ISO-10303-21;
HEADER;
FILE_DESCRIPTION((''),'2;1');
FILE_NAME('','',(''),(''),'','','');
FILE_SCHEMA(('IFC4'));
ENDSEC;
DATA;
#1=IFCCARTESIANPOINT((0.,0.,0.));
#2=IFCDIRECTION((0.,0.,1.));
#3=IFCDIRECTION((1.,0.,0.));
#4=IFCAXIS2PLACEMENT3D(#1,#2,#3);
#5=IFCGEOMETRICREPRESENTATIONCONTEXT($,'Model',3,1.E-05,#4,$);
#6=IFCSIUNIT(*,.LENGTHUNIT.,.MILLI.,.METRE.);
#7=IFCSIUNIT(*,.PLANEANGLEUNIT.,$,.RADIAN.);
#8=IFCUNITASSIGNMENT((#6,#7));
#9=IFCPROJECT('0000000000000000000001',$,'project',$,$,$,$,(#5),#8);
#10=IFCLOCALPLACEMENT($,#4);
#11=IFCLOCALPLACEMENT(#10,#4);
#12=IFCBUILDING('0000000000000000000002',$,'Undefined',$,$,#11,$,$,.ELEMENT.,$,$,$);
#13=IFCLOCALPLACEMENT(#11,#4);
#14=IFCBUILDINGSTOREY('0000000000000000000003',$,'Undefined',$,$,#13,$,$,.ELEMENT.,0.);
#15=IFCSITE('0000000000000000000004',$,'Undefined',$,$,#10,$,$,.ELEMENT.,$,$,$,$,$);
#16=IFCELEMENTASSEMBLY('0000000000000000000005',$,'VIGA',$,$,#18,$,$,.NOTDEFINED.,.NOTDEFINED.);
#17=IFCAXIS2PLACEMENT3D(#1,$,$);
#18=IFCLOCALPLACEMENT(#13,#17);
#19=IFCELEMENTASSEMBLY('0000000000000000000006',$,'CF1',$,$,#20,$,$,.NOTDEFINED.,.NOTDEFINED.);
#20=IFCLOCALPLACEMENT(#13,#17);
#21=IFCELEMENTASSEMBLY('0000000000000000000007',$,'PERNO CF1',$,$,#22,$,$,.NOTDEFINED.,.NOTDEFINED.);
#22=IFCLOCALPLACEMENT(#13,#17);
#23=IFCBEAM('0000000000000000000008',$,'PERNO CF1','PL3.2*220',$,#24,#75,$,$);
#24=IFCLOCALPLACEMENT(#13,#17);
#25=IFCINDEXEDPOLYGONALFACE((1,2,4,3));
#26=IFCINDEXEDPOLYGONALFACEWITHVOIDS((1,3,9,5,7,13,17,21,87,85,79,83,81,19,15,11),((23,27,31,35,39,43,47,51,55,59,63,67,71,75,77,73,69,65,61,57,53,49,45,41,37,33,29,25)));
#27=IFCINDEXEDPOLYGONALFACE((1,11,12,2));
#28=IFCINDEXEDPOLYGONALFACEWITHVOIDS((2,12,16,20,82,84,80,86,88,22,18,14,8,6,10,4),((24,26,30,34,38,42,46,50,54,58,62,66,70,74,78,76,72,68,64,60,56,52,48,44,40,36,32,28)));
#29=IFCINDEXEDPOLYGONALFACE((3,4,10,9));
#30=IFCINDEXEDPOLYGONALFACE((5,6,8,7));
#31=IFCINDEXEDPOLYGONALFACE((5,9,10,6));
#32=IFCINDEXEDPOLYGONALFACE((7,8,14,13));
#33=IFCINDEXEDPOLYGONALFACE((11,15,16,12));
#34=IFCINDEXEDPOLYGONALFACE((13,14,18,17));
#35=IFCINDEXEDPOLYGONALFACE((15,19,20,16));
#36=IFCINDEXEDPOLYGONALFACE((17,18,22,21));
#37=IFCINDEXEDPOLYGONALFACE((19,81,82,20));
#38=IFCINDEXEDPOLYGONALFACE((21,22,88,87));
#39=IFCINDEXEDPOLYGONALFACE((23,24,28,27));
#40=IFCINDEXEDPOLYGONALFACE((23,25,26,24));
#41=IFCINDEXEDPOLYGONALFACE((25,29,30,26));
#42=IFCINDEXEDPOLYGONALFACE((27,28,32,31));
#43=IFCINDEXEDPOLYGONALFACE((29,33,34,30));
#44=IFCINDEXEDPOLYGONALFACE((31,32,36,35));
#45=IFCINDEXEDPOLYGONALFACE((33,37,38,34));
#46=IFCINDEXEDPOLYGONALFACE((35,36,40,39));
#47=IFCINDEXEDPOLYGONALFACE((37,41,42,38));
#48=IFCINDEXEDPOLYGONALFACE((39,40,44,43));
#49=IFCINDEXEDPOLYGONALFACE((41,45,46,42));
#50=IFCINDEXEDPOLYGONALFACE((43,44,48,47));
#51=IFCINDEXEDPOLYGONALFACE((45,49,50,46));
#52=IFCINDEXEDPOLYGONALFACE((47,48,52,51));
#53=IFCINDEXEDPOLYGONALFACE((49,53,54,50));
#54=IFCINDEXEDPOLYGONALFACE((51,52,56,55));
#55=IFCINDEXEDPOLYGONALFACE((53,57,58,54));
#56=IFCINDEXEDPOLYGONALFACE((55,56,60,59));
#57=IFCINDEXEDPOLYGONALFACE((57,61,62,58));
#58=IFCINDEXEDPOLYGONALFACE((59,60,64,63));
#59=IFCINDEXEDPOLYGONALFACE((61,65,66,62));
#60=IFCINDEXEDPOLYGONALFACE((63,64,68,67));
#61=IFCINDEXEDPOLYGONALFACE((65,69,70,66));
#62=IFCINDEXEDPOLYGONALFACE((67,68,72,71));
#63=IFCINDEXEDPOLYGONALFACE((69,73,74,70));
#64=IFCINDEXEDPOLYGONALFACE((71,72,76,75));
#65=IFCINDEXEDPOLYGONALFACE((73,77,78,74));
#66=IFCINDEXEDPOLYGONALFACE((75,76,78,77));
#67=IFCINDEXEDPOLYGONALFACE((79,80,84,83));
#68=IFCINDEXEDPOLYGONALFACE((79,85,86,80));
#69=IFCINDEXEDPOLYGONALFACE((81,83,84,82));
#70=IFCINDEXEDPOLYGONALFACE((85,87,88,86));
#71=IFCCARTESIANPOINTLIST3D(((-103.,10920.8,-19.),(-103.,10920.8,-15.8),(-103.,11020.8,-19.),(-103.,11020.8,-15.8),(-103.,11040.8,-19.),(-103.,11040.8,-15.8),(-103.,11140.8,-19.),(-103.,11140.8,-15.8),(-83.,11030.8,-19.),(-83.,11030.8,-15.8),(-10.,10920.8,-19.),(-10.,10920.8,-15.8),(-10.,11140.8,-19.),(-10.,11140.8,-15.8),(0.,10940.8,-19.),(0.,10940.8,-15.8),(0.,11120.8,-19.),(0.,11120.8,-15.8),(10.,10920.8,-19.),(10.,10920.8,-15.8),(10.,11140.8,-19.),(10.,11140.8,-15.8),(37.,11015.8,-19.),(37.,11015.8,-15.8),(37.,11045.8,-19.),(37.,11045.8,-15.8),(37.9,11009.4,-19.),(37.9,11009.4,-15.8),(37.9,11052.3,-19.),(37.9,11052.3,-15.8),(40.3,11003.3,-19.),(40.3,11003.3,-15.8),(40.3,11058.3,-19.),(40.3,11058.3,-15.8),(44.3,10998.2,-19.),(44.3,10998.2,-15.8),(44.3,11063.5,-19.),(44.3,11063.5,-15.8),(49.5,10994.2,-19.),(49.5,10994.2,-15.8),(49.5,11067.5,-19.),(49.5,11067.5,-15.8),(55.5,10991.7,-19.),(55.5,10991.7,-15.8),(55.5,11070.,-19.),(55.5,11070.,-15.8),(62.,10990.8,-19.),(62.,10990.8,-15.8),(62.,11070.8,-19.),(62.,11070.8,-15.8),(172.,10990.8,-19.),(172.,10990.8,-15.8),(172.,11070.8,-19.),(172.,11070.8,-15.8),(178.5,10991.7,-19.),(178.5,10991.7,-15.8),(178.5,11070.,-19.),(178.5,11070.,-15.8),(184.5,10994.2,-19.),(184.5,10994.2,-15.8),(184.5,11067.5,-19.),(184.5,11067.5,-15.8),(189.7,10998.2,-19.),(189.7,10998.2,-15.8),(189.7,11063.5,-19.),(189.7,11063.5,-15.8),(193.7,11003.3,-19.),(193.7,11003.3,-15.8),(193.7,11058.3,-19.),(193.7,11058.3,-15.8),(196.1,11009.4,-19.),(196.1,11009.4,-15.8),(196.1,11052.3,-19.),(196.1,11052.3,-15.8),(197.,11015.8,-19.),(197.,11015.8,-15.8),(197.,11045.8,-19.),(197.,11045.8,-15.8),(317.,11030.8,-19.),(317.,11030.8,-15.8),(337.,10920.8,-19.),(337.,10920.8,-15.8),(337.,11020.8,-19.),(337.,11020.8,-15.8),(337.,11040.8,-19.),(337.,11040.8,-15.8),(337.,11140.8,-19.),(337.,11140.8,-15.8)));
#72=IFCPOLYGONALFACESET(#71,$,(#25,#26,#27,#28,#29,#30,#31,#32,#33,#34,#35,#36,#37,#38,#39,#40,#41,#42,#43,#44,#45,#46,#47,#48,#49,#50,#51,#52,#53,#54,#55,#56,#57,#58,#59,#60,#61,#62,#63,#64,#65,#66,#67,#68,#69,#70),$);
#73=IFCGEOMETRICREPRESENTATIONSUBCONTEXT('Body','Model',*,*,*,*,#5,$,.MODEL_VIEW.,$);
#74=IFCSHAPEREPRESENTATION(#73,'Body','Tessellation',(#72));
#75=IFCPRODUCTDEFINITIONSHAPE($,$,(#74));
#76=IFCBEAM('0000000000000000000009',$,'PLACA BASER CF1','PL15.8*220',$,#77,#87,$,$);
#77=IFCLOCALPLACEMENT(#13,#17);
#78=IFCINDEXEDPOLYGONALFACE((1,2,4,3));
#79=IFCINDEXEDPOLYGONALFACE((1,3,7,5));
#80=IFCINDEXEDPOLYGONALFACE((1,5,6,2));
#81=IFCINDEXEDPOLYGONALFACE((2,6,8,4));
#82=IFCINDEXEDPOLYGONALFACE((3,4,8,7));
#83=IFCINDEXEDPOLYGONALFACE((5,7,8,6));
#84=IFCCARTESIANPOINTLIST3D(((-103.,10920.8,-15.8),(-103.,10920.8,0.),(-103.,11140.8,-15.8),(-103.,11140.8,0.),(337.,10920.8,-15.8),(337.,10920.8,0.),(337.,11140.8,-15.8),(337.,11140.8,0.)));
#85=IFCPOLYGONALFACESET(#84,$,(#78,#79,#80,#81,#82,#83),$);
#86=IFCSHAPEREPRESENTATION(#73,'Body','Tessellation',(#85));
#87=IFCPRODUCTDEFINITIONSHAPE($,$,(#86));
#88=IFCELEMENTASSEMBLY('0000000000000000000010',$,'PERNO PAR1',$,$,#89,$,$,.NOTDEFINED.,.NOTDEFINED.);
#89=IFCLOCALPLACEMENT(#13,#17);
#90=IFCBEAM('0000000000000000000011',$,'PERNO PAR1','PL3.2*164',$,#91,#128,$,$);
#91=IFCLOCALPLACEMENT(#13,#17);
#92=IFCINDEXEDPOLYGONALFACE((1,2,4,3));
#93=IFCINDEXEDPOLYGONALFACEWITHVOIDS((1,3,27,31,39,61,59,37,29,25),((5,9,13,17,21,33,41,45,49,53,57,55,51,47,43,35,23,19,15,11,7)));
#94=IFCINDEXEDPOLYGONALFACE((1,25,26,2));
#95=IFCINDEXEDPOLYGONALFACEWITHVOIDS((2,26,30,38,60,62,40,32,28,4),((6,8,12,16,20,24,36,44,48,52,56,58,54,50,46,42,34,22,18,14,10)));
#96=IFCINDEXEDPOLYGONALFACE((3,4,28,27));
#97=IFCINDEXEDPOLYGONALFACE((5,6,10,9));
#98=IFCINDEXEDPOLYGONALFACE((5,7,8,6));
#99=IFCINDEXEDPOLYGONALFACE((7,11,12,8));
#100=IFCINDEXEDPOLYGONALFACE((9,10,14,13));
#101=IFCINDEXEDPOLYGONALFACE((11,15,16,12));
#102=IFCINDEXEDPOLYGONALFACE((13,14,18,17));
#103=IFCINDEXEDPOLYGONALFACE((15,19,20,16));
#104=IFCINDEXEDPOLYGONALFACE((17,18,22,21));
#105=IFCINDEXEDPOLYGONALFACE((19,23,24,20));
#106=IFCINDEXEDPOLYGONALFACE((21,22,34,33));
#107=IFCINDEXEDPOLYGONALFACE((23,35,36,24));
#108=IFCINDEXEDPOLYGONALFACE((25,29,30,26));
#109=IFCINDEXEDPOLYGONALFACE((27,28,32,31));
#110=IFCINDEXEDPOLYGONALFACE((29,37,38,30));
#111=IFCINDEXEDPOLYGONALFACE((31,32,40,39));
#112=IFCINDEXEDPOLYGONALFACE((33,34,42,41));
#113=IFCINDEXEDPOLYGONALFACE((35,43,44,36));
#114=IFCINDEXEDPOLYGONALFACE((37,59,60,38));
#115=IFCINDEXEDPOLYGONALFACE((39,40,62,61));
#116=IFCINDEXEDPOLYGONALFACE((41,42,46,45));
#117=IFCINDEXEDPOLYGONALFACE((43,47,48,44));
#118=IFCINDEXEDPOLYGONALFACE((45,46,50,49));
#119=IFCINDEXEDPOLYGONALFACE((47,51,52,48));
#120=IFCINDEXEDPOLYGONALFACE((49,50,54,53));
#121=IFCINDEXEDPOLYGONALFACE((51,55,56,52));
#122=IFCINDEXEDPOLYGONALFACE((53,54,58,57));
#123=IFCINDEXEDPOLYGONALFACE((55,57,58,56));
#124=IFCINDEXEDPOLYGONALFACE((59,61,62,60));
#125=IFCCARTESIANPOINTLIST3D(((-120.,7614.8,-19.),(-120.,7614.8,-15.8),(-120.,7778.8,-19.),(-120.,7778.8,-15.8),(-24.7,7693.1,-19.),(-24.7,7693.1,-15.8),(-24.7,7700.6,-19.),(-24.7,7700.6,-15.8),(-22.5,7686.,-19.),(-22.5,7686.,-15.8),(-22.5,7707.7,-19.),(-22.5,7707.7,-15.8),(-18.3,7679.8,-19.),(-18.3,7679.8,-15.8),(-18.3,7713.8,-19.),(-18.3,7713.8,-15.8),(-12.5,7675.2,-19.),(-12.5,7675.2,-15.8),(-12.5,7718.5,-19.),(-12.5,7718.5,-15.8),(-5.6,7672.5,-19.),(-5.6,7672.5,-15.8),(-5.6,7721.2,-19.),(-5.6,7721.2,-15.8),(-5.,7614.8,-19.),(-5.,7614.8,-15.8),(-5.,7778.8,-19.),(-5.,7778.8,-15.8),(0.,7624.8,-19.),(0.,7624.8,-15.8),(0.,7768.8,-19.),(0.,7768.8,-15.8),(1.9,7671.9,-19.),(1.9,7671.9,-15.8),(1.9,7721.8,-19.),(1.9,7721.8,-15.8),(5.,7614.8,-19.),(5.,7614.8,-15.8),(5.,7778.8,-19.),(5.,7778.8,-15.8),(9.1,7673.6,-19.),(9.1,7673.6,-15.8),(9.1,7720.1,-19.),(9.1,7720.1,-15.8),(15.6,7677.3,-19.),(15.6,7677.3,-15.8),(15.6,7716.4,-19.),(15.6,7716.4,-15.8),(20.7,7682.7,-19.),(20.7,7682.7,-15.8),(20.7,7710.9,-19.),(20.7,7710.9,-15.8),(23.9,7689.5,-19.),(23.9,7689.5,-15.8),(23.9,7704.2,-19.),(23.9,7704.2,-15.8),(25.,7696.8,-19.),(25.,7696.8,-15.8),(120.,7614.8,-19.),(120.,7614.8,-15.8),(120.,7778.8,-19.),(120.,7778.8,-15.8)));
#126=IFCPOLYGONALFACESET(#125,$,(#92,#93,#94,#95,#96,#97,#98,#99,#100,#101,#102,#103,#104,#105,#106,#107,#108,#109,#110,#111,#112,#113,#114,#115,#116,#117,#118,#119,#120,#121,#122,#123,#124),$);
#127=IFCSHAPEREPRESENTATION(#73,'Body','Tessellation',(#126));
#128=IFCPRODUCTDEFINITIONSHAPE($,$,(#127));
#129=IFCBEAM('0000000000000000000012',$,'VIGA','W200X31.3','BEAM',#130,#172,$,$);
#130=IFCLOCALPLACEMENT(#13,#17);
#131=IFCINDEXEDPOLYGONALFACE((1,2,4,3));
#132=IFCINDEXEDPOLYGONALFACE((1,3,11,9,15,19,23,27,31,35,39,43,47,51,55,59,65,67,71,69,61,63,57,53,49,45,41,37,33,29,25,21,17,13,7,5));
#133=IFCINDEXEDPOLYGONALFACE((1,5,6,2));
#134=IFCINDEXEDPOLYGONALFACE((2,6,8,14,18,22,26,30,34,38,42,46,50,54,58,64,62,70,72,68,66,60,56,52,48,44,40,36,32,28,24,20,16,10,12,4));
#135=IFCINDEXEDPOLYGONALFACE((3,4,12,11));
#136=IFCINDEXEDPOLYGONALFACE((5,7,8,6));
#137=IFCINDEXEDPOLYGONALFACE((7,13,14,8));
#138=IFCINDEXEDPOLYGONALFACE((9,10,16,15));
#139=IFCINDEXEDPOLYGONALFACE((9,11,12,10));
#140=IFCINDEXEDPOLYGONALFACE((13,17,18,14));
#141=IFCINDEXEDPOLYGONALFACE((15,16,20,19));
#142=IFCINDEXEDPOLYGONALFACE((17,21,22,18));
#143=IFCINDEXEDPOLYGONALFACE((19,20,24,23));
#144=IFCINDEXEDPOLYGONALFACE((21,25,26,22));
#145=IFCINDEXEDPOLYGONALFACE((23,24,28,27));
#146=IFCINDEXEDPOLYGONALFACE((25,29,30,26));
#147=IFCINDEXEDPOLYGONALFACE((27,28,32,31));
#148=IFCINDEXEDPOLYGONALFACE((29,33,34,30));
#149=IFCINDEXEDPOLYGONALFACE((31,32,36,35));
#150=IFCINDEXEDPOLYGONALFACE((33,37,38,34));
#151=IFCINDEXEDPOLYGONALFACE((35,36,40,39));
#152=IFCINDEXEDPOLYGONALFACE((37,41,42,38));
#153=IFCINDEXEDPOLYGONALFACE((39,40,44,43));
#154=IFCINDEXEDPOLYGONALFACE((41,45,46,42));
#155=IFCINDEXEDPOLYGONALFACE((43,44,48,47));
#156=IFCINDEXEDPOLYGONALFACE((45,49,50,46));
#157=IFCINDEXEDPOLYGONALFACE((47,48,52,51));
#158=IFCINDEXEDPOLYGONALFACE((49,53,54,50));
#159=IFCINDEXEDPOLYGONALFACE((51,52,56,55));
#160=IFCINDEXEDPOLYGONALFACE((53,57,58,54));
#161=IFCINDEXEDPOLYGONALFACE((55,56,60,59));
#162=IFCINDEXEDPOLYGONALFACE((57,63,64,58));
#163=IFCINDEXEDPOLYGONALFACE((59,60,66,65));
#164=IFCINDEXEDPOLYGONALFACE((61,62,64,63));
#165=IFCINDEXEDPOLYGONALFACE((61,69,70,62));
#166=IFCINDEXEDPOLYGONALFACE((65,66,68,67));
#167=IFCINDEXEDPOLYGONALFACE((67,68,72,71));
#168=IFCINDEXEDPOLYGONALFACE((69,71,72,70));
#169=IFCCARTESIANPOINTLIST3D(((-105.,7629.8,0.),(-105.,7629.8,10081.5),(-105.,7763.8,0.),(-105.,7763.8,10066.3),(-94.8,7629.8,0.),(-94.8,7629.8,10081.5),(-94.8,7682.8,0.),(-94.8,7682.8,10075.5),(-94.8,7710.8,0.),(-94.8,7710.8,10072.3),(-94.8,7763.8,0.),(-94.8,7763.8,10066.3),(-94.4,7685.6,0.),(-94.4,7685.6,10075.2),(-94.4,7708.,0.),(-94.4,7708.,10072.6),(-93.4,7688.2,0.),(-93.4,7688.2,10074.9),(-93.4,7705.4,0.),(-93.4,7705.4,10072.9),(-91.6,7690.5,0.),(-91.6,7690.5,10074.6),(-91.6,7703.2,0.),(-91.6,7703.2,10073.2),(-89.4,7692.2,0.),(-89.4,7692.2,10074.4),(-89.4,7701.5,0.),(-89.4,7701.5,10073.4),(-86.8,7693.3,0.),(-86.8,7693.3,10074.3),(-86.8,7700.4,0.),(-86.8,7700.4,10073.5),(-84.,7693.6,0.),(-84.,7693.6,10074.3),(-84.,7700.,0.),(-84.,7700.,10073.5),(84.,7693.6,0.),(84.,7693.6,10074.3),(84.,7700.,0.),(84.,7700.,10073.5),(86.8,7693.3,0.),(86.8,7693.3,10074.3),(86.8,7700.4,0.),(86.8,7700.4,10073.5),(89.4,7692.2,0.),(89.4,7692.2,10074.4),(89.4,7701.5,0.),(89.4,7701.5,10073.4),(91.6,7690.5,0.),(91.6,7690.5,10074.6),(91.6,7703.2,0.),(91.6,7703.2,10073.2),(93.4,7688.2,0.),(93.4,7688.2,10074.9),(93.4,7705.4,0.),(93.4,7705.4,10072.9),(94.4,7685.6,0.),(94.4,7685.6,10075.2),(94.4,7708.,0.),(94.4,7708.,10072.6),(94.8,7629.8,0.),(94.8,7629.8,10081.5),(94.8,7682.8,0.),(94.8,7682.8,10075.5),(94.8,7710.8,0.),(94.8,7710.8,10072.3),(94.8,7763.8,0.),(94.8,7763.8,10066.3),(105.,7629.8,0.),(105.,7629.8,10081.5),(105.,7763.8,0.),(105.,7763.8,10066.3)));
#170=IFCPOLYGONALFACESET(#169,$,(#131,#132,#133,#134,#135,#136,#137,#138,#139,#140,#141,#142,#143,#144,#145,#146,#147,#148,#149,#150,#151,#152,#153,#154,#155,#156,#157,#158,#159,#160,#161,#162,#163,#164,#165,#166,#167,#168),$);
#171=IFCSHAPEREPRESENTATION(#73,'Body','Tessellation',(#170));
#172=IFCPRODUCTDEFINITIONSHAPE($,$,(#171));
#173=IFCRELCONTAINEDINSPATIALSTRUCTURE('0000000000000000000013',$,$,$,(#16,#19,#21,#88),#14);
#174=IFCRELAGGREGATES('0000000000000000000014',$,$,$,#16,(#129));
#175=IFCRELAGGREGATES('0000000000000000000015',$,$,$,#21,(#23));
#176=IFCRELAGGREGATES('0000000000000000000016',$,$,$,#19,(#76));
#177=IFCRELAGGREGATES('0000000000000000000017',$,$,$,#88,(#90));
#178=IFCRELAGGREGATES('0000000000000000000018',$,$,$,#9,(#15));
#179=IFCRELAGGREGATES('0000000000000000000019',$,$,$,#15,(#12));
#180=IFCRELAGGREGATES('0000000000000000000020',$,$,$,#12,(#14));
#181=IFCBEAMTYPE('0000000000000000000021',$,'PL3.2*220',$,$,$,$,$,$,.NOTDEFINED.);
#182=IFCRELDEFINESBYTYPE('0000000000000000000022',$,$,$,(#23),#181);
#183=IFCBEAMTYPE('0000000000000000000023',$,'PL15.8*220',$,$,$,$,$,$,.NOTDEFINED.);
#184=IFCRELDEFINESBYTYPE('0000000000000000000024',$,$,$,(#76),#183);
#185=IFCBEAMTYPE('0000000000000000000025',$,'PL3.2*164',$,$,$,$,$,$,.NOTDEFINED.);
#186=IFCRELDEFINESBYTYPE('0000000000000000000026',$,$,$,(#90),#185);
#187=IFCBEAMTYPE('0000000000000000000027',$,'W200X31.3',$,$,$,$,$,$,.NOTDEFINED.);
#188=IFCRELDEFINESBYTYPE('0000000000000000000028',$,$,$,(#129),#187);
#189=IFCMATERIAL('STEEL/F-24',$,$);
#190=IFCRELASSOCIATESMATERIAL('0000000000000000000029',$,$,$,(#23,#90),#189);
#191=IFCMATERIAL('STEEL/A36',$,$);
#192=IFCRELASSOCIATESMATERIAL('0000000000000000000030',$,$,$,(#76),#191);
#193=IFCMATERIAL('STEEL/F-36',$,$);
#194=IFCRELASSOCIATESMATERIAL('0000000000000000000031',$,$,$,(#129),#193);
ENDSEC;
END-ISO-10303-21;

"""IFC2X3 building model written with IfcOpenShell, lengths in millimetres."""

from ifc_helpers import new_model, si_unit, frame, frame_2d, origin_with_axes, origin_2d_with_axis, place, context, subcontext, project, spatial, polyline, circle_curve, parameter, trimmed, segment, composite_curve, rectangle, i_section, outline, extrude, boolean, clip, halfspace, material, type_object, element, aggregate, save


model = new_model("IFC2X3")

# Units and contexts
model_context = context("Model", 3, precision=1e-05, world=origin_with_axes())
body_context = subcontext(model_context, "Body", "Model", "MODEL_VIEW")
ifc_project = project(units=[si_unit("LENGTHUNIT", "METRE", prefix="MILLI"), si_unit("PLANEANGLEUNIT", "RADIAN")], contexts=[model_context])

# Site, building, storey
site_placement = place(None, origin_with_axes())
site = spatial("IfcSite", under=ifc_project, at=site_placement, Name="Undefined", CompositionType="ELEMENT")
building_placement = place(site_placement, origin_with_axes())
building = spatial("IfcBuilding", under=site, at=building_placement, Name="Undefined", CompositionType="ELEMENT")
storey_placement = place(building_placement, origin_with_axes())
storey = spatial("IfcBuildingStorey", under=building, at=storey_placement, Name="Undefined", CompositionType="ELEMENT", Elevation=0.0)

# Element assembly
ifc_material_1 = material(Name="STEEL/F-36")
ifc_material_2 = material(Name="STEEL/F-24")
assembly_1_placement = place(storey_placement, origin_with_axes())
assembly_1 = element("IfcElementAssembly", 1, at=assembly_1_placement, inside=storey, Name="VIGA", AssemblyPlace="NOTDEFINED", PredefinedType="NOTDEFINED")
ifc_material_3 = material(Name="STEEL/A36")

# Element assembly
assembly_2_placement = place(storey_placement, origin_with_axes())
assembly_2 = element("IfcElementAssembly", 2, at=assembly_2_placement, inside=storey, Name="CF1", AssemblyPlace="NOTDEFINED", PredefinedType="NOTDEFINED")

# Element assembly, beam
assembly_3_placement = place(storey_placement, origin_with_axes())
assembly_3 = element("IfcElementAssembly", 3, at=assembly_3_placement, inside=storey, Name="PERNO CF1", AssemblyPlace="NOTDEFINED", PredefinedType="NOTDEFINED")
beam_type_1 = type_object("IfcBeamType", Name="PL3.2*220", PredefinedType="NOTDEFINED")
beam_1_placement = place(assembly_3_placement, frame((-103.0, 11030.8, -17.4), z_axis=(0.0, -1.0, 0.0), x_axis=(1.0, 0.0, 0.0)))
beam_1 = element("IfcBeam", 4, at=beam_1_placement, type_object=beam_type_1, material=ifc_material_2, Name="PERNO CF1", Description="PL3.2*220", context=body_context, shape_type="CSG", body=[
    boolean("DIFFERENCE", boolean("DIFFERENCE", boolean("DIFFERENCE", boolean("DIFFERENCE", boolean("DIFFERENCE", extrude(rectangle(XDim=3.2, YDim=220.0, at=origin_2d_with_axis()), frame((440.0, 0.0, 0.0), z_axis=(-1.0, 0.0, 0.0), x_axis=(0.0, -1.0, 0.0)), (0.0, 0.0, 1.0), 440.0), extrude(outline(composite_curve([segment(trimmed(circle_curve(frame_2d((25.0, 25.0), x_axis=(-1.0, 0.0)), 25.0), [parameter(0.0)], [parameter(1.570796)], True, "PARAMETER"), True, "CONTINUOUS"), segment(polyline([(25.0, 0.0), (55.0, 0.0)]), True, "CONTINUOUS"), segment(trimmed(circle_curve(frame_2d((55.0, 25.0), x_axis=(0.0, -1.0)), 25.0), [parameter(0.0)], [parameter(1.570796)], True, "PARAMETER"), True, "CONTINUOUS"), segment(polyline([(80.0, 25.0), (80.0, 135.0)]), True, "CONTINUOUS"), segment(trimmed(circle_curve(frame_2d((55.0, 135.0), x_axis=(1.0, 0.0)), 25.0), [parameter(0.0)], [parameter(1.570796)], True, "PARAMETER"), True, "CONTINUOUS"), segment(polyline([(55.0, 160.0), (25.0, 160.0)]), True, "CONTINUOUS"), segment(trimmed(circle_curve(frame_2d((25.0, 135.0), x_axis=(0.0, 1.0)), 25.0), [parameter(0.0)], [parameter(1.570796)], True, "PARAMETER"), True, "CONTINUOUS"), segment(polyline([(0.0, 135.0), (0.0, 25.0)]), True, "CONTINUOUS")], self_intersect=True)), frame((140.0, 4.5, 40.0), z_axis=(0.0, -1.0, 0.0), x_axis=(0.0, 0.0, -1.0)), (0.0, 0.0, 1.0), 9.0)), extrude(outline(polyline([(0.0, 0.0), (20.0, 0.0), (10.0, 20.0), (0.0, 0.0)])), frame((440.0, -4.5, 10.0), z_axis=(0.0, 1.0, 0.0), x_axis=(0.0, 0.0, -1.0)), (0.0, 0.0, 1.0), 9.0)), extrude(outline(polyline([(0.0, 0.0), (20.0, 0.0), (10.0, 20.0), (0.0, 0.0)])), frame((0.0, 4.5, 10.0), z_axis=(0.0, -1.0, 0.0), x_axis=(0.0, 0.0, -1.0)), (0.0, 0.0, 1.0), 9.0)), extrude(outline(polyline([(0.0, 0.0), (20.0, 0.0), (10.0, 20.0), (0.0, 0.0)])), frame((93.0, -4.5, 110.0), z_axis=(0.0, 1.0, 0.0), x_axis=(1.0, 0.0, 0.0)), (0.0, 0.0, 1.0), 9.0)), extrude(outline(polyline([(0.0, 0.0), (20.0, 0.0), (10.0, 20.0), (0.0, 0.0)])), frame((93.0, 4.5, -110.0), z_axis=(0.0, -1.0, 0.0), x_axis=(1.0, 0.0, 0.0)), (0.0, 0.0, 1.0), 9.0)),
])

# Beam
beam_type_2 = type_object("IfcBeamType", Name="PL15.8*220", PredefinedType="NOTDEFINED")
beam_2_placement = place(assembly_2_placement, frame((-103.0, 11030.8, -7.9), z_axis=(0.0, -1.0, 0.0), x_axis=(1.0, 0.0, 0.0)))
beam_2 = element("IfcBeam", 5, at=beam_2_placement, type_object=beam_type_2, material=ifc_material_3, Name="PLACA BASER CF1", Description="PL15.8*220", context=body_context, shape_type="SweptSolid", body=[
    extrude(rectangle(XDim=15.8, YDim=220.0, at=origin_2d_with_axis()), frame((440.0, 0.0, 0.0), z_axis=(-1.0, 0.0, 0.0), x_axis=(0.0, -1.0, 0.0)), (0.0, 0.0, 1.0), 440.0),
])

# Element assembly, beam
assembly_4_placement = place(storey_placement, origin_with_axes())
assembly_4 = element("IfcElementAssembly", 6, at=assembly_4_placement, inside=storey, Name="PERNO PAR1", AssemblyPlace="NOTDEFINED", PredefinedType="NOTDEFINED")
beam_type_3 = type_object("IfcBeamType", Name="PL3.2*164", PredefinedType="NOTDEFINED")
beam_3_placement = place(assembly_4_placement, frame((-120.0, 7696.8, -17.4), z_axis=(0.0, -1.0, 0.0), x_axis=(1.0, 0.0, 0.0)))
beam_3 = element("IfcBeam", 7, at=beam_3_placement, type_object=beam_type_3, material=ifc_material_2, Name="PERNO PAR1", Description="PL3.2*164", context=body_context, shape_type="CSG", body=[
    boolean("DIFFERENCE", boolean("DIFFERENCE", boolean("DIFFERENCE", extrude(rectangle(XDim=3.2, YDim=164.0, at=origin_2d_with_axis()), frame((240.0, 0.0, 0.0), z_axis=(-1.0, 0.0, 0.0), x_axis=(0.0, -1.0, 0.0)), (0.0, 0.0, 1.0), 240.0), extrude(outline(composite_curve([segment(trimmed(circle_curve(frame_2d((25.0, 25.0), x_axis=(-1.0, 0.0)), 25.0), [parameter(0.0)], [parameter(1.570796)], True, "PARAMETER"), True, "CONTINUOUS"), segment(polyline([(25.0, 0.0), (25.0, 0.0)]), True, "CONTINUOUS"), segment(trimmed(circle_curve(frame_2d((25.0, 25.0), x_axis=(0.0, -1.0)), 25.0), [parameter(0.0)], [parameter(1.570796)], True, "PARAMETER"), True, "CONTINUOUS"), segment(polyline([(50.0, 25.0), (50.0, 25.0)]), True, "CONTINUOUS"), segment(trimmed(circle_curve(frame_2d((25.0, 25.0), x_axis=(1.0, 0.0)), 25.0), [parameter(0.0)], [parameter(1.570796)], True, "PARAMETER"), True, "CONTINUOUS"), segment(polyline([(25.0, 50.0), (25.0, 50.0)]), True, "CONTINUOUS"), segment(trimmed(circle_curve(frame_2d((25.0, 25.0), x_axis=(0.0, 1.0)), 25.0), [parameter(0.0)], [parameter(1.570796)], True, "PARAMETER"), True, "CONTINUOUS"), segment(polyline([(0.0, 25.0), (0.0, 25.0)]), True, "CONTINUOUS")], self_intersect=True)), frame((95.0, -4.5, 25.0), z_axis=(0.0, 1.0, 0.0), x_axis=(1.0, 0.0, 0.0)), (0.0, 0.0, 1.0), 9.0)), extrude(outline(polyline([(0.0, 0.0), (10.0, 0.0), (5.0, 10.0), (0.0, 0.0)])), frame((115.0, -4.5, 82.0), z_axis=(0.0, 1.0, 0.0), x_axis=(1.0, 0.0, 0.0)), (0.0, 0.0, 1.0), 9.0)), extrude(outline(polyline([(0.0, 0.0), (10.0, 0.0), (5.0, 10.0), (0.0, 0.0)])), frame((115.0, 4.5, -82.0), z_axis=(0.0, -1.0, 0.0), x_axis=(1.0, 0.0, 0.0)), (0.0, 0.0, 1.0), 9.0)),
])

# Beam
beam_type_4 = type_object("IfcBeamType", Name="W200X31.3", PredefinedType="NOTDEFINED")
beam_4_placement = place(assembly_1_placement, frame((0.0, 7696.8, 0.0), z_axis=(-1.0, 0.0, 0.0), x_axis=(0.0, 0.0, 1.0)))
beam_4 = element("IfcBeam", 8, at=beam_4_placement, type_object=beam_type_4, material=ifc_material_1, Name="VIGA", Description="W200X31.3", ObjectType="BEAM", context=body_context, shape_type="Clipping", body=[
    clip(extrude(i_section(OverallWidth=134.0, OverallDepth=210.0, WebThickness=6.4, FlangeThickness=10.2, FilletRadius=10.8, at=origin_2d_with_axis()), frame((10100.0, 0.0, 0.0), z_axis=(-1.0, 0.0, 0.0), x_axis=(0.0, -1.0, 0.0)), (0.0, 0.0, 1.0), 10100.0), halfspace(frame((10073.9, 0.0, 0.0), z_axis=(0.993634, 0.112653, 0.0), x_axis=(-0.112653, 0.993634, 0.0)), False)),
])

aggregate(assembly_1, [beam_4])

aggregate(assembly_3, [beam_1])
aggregate(assembly_2, [beam_2])
aggregate(assembly_4, [beam_3])

save(model, "model.ifc")
